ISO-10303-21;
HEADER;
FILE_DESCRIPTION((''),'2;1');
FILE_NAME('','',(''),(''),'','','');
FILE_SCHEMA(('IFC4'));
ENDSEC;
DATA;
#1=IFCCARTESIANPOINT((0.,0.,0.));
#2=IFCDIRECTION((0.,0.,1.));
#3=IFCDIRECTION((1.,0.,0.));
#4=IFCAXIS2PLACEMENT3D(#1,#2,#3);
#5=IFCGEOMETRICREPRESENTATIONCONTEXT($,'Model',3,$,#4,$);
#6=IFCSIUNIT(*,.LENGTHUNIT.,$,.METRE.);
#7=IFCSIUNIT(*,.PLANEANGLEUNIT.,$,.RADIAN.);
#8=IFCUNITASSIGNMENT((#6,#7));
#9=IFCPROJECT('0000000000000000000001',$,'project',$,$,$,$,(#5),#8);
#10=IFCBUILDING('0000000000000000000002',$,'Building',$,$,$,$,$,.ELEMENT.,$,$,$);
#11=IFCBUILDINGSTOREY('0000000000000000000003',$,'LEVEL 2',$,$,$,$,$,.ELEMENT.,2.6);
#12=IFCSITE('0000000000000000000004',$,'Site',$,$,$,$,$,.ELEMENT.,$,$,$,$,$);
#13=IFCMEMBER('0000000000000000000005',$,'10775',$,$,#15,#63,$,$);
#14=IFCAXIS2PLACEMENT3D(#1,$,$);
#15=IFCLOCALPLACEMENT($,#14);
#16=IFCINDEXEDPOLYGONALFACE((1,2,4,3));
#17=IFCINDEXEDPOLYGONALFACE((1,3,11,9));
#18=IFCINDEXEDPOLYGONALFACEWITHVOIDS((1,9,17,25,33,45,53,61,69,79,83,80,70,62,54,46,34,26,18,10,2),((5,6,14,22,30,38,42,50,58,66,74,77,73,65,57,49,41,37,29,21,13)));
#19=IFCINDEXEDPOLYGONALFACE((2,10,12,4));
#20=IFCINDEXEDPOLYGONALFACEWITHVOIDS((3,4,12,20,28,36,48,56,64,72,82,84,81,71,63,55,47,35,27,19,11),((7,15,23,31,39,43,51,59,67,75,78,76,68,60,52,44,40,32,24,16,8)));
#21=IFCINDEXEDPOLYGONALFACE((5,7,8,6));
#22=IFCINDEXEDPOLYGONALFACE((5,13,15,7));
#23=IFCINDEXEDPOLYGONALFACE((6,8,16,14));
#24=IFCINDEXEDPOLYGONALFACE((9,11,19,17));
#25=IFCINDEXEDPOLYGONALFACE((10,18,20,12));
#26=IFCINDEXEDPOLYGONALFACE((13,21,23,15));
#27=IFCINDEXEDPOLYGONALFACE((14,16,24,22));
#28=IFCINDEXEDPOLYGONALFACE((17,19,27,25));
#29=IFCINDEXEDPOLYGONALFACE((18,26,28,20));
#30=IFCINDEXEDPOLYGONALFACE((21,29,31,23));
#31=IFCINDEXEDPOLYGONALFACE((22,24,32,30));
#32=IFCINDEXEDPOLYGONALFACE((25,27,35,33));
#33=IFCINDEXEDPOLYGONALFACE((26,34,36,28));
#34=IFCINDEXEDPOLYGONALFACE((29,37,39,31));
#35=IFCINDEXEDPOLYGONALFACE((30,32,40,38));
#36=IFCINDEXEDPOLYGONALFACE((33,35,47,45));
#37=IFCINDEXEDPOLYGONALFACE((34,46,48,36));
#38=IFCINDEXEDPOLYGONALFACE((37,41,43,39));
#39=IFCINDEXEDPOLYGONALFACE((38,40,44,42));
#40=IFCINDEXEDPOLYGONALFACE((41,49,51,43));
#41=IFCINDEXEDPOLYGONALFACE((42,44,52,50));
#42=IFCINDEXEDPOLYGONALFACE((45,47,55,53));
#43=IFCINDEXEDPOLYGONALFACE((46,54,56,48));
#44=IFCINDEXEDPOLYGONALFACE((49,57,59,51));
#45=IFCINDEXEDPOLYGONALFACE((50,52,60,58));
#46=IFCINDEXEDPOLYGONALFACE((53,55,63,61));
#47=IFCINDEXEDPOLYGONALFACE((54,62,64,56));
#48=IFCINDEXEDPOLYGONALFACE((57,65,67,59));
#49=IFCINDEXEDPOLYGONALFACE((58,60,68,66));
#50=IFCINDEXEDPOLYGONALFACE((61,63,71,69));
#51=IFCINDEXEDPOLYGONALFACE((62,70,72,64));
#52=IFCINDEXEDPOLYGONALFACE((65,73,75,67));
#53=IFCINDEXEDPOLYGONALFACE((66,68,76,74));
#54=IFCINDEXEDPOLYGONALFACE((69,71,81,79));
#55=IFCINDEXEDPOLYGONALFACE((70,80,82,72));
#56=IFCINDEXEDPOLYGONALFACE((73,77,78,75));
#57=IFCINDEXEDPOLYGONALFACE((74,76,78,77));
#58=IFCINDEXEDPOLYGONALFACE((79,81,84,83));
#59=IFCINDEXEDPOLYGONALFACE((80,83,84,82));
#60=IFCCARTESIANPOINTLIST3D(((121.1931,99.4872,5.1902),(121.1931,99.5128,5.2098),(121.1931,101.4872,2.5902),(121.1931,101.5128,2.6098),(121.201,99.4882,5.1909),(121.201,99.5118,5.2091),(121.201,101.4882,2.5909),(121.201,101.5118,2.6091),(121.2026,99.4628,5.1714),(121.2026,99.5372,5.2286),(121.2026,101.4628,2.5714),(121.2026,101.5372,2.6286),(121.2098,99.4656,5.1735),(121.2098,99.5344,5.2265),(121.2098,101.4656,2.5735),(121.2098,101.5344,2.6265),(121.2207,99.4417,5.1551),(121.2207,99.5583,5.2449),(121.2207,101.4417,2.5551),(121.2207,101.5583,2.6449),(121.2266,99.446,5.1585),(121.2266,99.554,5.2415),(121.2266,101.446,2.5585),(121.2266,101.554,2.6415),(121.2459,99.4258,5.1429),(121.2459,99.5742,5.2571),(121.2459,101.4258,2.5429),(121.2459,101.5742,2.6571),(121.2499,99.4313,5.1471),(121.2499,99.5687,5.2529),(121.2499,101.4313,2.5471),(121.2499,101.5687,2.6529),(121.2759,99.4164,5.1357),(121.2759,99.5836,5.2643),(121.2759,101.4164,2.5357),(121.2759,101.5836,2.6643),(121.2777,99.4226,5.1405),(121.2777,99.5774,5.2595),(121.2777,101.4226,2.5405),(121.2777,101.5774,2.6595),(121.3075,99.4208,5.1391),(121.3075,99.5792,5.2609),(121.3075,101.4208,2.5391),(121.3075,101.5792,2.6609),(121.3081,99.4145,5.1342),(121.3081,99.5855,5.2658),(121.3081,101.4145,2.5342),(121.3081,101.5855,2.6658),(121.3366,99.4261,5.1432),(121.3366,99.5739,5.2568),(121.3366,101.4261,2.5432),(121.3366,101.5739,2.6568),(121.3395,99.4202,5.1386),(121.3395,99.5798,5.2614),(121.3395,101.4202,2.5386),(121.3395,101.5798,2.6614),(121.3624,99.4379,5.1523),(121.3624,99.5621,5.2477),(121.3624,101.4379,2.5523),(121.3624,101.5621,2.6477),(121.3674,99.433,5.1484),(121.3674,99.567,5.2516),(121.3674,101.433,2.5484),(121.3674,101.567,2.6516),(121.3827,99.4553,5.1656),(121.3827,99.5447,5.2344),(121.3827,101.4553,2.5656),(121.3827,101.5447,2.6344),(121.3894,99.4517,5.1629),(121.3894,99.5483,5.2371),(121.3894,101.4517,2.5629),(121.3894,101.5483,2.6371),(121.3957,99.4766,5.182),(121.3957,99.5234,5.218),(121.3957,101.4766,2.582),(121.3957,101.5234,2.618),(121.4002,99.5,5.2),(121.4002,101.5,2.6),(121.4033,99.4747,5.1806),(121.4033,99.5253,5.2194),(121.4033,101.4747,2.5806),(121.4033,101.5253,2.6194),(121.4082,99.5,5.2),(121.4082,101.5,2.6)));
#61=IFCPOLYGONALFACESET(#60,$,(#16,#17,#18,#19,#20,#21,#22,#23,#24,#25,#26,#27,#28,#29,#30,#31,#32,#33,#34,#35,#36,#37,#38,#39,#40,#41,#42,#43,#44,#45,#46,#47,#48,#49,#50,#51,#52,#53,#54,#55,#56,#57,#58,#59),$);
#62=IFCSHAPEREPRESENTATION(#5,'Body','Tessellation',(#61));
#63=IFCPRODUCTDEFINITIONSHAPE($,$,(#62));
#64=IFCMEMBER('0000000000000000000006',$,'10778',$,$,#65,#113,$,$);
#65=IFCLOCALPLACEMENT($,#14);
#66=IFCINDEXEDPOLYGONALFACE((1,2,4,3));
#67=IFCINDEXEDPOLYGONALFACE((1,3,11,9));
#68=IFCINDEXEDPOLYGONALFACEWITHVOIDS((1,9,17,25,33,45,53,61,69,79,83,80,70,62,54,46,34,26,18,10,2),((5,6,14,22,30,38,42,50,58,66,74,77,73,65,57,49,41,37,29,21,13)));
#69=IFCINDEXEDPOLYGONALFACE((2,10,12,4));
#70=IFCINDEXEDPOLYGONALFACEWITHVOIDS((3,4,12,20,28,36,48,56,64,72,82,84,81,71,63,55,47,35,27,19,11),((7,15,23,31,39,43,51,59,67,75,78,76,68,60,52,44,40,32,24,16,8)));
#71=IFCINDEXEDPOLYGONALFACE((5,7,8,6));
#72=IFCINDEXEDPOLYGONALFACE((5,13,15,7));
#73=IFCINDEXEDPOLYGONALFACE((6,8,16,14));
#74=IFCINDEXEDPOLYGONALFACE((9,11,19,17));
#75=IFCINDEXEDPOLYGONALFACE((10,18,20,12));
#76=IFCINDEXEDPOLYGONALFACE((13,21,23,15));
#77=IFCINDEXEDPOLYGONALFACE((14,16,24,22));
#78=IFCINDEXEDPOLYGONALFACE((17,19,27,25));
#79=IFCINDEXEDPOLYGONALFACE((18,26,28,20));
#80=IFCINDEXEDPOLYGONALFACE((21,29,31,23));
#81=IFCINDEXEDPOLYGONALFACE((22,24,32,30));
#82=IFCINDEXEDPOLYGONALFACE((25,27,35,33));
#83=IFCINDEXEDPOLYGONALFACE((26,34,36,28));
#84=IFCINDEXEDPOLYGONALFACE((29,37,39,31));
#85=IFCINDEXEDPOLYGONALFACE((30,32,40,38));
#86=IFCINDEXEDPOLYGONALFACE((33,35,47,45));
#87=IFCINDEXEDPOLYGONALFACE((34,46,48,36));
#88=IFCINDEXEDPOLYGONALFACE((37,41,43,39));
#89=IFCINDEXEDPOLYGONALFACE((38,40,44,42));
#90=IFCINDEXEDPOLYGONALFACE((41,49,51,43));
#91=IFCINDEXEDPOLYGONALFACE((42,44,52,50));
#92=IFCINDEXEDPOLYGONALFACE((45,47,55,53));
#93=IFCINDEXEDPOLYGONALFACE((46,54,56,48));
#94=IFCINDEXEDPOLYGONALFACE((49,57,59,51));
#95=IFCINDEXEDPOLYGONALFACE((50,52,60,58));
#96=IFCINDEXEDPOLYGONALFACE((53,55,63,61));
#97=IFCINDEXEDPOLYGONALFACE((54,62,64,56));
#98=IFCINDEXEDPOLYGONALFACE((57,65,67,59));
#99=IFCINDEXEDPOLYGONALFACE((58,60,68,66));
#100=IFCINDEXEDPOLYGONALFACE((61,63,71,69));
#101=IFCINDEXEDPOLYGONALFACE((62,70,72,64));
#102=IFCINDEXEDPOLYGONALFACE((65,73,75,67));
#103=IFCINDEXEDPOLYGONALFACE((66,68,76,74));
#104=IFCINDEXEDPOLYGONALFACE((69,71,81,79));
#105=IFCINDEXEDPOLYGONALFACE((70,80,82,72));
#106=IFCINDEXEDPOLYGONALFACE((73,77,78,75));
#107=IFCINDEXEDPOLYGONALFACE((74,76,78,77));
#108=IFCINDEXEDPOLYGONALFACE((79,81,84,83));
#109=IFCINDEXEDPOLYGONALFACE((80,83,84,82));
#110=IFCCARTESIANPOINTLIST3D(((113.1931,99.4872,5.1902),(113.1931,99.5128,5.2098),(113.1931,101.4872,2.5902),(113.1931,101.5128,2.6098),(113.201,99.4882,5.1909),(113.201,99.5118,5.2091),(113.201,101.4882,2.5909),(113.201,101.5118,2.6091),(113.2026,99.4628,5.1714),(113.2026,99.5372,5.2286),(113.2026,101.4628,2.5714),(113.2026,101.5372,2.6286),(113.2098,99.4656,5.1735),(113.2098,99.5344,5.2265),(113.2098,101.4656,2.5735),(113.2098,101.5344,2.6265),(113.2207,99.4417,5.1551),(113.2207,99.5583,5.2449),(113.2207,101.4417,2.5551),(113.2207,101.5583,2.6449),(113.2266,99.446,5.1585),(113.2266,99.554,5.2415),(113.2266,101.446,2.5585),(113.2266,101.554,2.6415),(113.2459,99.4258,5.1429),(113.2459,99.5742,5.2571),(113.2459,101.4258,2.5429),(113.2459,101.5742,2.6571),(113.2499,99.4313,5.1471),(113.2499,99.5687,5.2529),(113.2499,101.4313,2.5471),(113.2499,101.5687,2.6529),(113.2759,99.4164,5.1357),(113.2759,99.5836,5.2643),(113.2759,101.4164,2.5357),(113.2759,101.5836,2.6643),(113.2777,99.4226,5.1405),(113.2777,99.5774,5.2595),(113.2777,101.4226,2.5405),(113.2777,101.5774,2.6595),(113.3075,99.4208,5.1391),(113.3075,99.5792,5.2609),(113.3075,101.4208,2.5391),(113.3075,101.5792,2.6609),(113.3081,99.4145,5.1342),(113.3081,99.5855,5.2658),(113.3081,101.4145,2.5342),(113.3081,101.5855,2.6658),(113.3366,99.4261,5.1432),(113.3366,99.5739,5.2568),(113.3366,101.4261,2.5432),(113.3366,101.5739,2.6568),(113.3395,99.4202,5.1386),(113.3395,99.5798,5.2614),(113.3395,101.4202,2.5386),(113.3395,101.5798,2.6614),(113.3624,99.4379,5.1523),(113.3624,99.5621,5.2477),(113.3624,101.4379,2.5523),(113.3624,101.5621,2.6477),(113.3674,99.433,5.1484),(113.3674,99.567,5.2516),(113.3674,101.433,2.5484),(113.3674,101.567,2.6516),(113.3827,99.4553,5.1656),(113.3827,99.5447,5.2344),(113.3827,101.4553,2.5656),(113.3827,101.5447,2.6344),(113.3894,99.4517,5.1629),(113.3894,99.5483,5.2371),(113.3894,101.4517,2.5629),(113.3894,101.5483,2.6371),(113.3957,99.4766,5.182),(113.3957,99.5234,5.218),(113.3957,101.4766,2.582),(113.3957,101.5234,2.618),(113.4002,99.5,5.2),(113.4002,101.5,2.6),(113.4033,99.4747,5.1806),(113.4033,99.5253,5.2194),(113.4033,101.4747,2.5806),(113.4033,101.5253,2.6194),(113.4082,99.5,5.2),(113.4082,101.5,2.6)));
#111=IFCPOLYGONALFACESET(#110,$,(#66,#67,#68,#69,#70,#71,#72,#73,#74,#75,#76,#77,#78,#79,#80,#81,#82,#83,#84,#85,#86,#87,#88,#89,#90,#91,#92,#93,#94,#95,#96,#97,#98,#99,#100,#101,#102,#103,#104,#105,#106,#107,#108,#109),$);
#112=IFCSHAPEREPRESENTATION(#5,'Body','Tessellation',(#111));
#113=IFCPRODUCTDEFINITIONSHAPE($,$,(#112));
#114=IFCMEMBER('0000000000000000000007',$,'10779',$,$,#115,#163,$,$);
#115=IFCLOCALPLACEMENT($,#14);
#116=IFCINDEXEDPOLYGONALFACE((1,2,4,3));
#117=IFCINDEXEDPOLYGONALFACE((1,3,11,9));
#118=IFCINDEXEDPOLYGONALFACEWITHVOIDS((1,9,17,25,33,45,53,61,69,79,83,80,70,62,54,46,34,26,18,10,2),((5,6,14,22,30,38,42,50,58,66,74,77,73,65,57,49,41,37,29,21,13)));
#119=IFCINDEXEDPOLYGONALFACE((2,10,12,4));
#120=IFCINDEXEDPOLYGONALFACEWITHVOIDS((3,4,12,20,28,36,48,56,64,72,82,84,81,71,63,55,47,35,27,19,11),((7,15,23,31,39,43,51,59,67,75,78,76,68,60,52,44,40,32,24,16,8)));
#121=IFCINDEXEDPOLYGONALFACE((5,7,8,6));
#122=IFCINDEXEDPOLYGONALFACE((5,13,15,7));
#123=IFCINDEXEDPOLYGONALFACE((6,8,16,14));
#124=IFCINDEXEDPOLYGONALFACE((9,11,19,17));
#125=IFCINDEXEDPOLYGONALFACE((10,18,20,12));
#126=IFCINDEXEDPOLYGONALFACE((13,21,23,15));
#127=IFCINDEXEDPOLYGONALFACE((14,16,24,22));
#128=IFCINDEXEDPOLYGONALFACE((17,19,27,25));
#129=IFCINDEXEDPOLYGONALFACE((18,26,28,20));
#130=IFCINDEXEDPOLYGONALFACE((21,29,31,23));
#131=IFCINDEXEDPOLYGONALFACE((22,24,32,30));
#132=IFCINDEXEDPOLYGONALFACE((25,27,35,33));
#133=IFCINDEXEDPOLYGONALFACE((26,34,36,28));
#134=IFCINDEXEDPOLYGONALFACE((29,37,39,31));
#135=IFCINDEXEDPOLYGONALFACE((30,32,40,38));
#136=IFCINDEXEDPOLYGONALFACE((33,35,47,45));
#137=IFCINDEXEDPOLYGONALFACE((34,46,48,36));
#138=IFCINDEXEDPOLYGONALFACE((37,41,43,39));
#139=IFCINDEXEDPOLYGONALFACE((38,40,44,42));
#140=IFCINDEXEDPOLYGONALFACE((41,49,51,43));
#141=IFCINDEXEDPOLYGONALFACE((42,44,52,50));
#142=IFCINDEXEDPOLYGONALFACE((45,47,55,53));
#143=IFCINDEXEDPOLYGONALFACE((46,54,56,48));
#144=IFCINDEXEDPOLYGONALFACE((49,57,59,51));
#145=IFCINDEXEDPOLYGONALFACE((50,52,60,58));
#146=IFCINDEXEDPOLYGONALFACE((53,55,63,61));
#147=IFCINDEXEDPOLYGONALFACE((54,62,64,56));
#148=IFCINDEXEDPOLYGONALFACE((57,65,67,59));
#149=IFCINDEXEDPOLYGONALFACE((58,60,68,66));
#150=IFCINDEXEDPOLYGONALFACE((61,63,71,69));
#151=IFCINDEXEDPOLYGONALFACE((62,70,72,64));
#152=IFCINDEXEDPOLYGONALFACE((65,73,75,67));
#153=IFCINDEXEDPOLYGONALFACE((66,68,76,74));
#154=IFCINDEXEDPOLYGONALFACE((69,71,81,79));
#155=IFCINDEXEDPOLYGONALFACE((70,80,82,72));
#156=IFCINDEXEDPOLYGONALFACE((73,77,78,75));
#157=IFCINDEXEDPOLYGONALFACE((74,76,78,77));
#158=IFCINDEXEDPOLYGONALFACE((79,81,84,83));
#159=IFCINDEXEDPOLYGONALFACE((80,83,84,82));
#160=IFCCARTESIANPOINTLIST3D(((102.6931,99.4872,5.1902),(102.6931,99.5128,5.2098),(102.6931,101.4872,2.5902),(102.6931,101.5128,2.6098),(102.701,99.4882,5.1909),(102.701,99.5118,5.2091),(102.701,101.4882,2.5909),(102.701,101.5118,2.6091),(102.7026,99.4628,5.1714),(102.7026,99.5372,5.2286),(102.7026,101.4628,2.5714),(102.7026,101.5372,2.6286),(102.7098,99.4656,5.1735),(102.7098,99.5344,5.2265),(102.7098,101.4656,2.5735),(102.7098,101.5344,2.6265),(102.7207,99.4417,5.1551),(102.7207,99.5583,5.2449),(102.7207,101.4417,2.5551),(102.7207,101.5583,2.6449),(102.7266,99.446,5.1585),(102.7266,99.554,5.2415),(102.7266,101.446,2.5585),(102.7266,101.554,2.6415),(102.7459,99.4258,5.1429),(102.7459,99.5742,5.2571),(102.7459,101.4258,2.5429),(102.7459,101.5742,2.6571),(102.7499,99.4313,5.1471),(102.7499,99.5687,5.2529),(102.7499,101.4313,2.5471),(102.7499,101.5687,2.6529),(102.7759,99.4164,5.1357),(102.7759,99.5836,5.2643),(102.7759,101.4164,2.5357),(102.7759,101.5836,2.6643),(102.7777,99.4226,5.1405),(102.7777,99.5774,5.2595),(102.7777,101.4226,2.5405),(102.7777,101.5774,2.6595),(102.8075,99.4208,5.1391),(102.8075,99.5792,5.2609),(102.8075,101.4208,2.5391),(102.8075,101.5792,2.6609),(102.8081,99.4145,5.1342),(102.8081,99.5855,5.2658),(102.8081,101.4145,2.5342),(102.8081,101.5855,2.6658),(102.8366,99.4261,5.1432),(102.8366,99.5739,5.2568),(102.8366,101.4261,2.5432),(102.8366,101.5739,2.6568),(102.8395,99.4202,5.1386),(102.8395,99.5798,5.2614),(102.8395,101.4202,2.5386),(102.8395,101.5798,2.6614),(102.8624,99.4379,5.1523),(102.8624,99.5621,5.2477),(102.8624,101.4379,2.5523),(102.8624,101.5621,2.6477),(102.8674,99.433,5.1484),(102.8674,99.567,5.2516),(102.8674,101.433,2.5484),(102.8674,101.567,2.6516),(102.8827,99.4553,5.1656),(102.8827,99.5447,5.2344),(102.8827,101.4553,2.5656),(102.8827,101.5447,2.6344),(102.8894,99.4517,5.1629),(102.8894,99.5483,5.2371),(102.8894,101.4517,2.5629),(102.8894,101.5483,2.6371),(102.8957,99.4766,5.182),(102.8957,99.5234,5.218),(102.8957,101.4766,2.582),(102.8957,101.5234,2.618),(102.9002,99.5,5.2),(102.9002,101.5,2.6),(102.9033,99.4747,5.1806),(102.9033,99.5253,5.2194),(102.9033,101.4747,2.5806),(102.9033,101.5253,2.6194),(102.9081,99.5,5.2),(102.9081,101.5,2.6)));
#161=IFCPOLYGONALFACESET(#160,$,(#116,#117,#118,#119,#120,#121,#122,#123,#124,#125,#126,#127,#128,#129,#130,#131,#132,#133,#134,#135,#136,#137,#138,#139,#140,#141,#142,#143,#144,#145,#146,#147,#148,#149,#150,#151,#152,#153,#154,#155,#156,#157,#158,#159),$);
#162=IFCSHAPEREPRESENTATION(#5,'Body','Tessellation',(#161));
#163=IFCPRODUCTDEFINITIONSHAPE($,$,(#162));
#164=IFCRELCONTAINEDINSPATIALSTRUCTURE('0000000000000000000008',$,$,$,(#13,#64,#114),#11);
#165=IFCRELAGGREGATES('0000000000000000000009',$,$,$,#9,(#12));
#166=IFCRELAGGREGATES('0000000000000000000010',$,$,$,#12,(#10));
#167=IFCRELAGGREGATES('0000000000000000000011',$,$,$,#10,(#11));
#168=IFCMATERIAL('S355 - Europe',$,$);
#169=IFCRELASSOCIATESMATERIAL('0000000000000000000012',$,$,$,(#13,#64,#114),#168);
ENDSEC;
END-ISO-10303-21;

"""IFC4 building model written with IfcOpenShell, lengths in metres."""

from ifc_helpers import new_model, si_unit, frame, origin_with_axes, origin_2d_with_axis, place, context, project, spatial, hollow_circle, extrude, material, material_profile, profile_set, profile_usage, element, save


model = new_model("IFC4")

# Units and contexts
model_context = context("Model", 3, world=origin_with_axes())
ifc_project = project(units=[si_unit("LENGTHUNIT", "METRE"), si_unit("PLANEANGLEUNIT", "RADIAN")], contexts=[model_context])

# Site, building, storey
site = spatial("IfcSite", under=ifc_project, Name="Site", CompositionType="ELEMENT")
building = spatial("IfcBuilding", under=site, Name="Building", CompositionType="ELEMENT")
storey = spatial("IfcBuildingStorey", under=building, Name="LEVEL 2", CompositionType="ELEMENT", Elevation=2.6)

# Shared definitions
ifc_material = material(Name="S355 - Europe")

# Members
ifc_material_profile_1 = material_profile(ifc_material, hollow_circle(Radius=0.1081, WallThickness=0.008, at=origin_2d_with_axis()))
ifc_profile_set_1 = profile_set([ifc_material_profile_1])
ifc_profile_usage_1 = profile_usage(ifc_profile_set_1, cardinal=10)
member_1_placement = place(None, frame((121.3, 101.5, 2.6), z_axis=(0.0, -0.609711, 0.792624), x_axis=(1.0, 0.0, 0.0)))
element("IfcMember", 1, at=member_1_placement, inside=storey, material=ifc_profile_usage_1, Name="10775", context=model_context, shape_type="SweptSolid", body=[
    extrude(hollow_circle(Radius=0.1081, WallThickness=0.008, at=origin_2d_with_axis()), origin_with_axes(), (0.0, 0.0, 1.0), 3.2802),
])
ifc_material_profile_2 = material_profile(ifc_material, hollow_circle(Radius=0.1081, WallThickness=0.008, at=origin_2d_with_axis()))
ifc_profile_set_2 = profile_set([ifc_material_profile_2])
ifc_profile_usage_2 = profile_usage(ifc_profile_set_2, cardinal=10)
member_2_placement = place(None, frame((113.3, 101.5, 2.6), z_axis=(0.0, -0.609711, 0.792624), x_axis=(1.0, 0.0, 0.0)))
element("IfcMember", 2, at=member_2_placement, inside=storey, material=ifc_profile_usage_2, Name="10778", context=model_context, shape_type="SweptSolid", body=[
    extrude(hollow_circle(Radius=0.1081, WallThickness=0.008, at=origin_2d_with_axis()), origin_with_axes(), (0.0, 0.0, 1.0), 3.2802),
])
ifc_material_profile_3 = material_profile(ifc_material, hollow_circle(Radius=0.1081, WallThickness=0.008, at=origin_2d_with_axis()))
ifc_profile_set_3 = profile_set([ifc_material_profile_3])
ifc_profile_usage_3 = profile_usage(ifc_profile_set_3, cardinal=10)
member_3_placement = place(None, frame((102.8, 101.5, 2.6), z_axis=(0.0, -0.609711, 0.792624), x_axis=(1.0, 0.0, 0.0)))
element("IfcMember", 3, at=member_3_placement, inside=storey, material=ifc_profile_usage_3, Name="10779", context=model_context, shape_type="SweptSolid", body=[
    extrude(hollow_circle(Radius=0.1081, WallThickness=0.008, at=origin_2d_with_axis()), origin_with_axes(), (0.0, 0.0, 1.0), 3.2802),
])

save(model, "model.ifc")
